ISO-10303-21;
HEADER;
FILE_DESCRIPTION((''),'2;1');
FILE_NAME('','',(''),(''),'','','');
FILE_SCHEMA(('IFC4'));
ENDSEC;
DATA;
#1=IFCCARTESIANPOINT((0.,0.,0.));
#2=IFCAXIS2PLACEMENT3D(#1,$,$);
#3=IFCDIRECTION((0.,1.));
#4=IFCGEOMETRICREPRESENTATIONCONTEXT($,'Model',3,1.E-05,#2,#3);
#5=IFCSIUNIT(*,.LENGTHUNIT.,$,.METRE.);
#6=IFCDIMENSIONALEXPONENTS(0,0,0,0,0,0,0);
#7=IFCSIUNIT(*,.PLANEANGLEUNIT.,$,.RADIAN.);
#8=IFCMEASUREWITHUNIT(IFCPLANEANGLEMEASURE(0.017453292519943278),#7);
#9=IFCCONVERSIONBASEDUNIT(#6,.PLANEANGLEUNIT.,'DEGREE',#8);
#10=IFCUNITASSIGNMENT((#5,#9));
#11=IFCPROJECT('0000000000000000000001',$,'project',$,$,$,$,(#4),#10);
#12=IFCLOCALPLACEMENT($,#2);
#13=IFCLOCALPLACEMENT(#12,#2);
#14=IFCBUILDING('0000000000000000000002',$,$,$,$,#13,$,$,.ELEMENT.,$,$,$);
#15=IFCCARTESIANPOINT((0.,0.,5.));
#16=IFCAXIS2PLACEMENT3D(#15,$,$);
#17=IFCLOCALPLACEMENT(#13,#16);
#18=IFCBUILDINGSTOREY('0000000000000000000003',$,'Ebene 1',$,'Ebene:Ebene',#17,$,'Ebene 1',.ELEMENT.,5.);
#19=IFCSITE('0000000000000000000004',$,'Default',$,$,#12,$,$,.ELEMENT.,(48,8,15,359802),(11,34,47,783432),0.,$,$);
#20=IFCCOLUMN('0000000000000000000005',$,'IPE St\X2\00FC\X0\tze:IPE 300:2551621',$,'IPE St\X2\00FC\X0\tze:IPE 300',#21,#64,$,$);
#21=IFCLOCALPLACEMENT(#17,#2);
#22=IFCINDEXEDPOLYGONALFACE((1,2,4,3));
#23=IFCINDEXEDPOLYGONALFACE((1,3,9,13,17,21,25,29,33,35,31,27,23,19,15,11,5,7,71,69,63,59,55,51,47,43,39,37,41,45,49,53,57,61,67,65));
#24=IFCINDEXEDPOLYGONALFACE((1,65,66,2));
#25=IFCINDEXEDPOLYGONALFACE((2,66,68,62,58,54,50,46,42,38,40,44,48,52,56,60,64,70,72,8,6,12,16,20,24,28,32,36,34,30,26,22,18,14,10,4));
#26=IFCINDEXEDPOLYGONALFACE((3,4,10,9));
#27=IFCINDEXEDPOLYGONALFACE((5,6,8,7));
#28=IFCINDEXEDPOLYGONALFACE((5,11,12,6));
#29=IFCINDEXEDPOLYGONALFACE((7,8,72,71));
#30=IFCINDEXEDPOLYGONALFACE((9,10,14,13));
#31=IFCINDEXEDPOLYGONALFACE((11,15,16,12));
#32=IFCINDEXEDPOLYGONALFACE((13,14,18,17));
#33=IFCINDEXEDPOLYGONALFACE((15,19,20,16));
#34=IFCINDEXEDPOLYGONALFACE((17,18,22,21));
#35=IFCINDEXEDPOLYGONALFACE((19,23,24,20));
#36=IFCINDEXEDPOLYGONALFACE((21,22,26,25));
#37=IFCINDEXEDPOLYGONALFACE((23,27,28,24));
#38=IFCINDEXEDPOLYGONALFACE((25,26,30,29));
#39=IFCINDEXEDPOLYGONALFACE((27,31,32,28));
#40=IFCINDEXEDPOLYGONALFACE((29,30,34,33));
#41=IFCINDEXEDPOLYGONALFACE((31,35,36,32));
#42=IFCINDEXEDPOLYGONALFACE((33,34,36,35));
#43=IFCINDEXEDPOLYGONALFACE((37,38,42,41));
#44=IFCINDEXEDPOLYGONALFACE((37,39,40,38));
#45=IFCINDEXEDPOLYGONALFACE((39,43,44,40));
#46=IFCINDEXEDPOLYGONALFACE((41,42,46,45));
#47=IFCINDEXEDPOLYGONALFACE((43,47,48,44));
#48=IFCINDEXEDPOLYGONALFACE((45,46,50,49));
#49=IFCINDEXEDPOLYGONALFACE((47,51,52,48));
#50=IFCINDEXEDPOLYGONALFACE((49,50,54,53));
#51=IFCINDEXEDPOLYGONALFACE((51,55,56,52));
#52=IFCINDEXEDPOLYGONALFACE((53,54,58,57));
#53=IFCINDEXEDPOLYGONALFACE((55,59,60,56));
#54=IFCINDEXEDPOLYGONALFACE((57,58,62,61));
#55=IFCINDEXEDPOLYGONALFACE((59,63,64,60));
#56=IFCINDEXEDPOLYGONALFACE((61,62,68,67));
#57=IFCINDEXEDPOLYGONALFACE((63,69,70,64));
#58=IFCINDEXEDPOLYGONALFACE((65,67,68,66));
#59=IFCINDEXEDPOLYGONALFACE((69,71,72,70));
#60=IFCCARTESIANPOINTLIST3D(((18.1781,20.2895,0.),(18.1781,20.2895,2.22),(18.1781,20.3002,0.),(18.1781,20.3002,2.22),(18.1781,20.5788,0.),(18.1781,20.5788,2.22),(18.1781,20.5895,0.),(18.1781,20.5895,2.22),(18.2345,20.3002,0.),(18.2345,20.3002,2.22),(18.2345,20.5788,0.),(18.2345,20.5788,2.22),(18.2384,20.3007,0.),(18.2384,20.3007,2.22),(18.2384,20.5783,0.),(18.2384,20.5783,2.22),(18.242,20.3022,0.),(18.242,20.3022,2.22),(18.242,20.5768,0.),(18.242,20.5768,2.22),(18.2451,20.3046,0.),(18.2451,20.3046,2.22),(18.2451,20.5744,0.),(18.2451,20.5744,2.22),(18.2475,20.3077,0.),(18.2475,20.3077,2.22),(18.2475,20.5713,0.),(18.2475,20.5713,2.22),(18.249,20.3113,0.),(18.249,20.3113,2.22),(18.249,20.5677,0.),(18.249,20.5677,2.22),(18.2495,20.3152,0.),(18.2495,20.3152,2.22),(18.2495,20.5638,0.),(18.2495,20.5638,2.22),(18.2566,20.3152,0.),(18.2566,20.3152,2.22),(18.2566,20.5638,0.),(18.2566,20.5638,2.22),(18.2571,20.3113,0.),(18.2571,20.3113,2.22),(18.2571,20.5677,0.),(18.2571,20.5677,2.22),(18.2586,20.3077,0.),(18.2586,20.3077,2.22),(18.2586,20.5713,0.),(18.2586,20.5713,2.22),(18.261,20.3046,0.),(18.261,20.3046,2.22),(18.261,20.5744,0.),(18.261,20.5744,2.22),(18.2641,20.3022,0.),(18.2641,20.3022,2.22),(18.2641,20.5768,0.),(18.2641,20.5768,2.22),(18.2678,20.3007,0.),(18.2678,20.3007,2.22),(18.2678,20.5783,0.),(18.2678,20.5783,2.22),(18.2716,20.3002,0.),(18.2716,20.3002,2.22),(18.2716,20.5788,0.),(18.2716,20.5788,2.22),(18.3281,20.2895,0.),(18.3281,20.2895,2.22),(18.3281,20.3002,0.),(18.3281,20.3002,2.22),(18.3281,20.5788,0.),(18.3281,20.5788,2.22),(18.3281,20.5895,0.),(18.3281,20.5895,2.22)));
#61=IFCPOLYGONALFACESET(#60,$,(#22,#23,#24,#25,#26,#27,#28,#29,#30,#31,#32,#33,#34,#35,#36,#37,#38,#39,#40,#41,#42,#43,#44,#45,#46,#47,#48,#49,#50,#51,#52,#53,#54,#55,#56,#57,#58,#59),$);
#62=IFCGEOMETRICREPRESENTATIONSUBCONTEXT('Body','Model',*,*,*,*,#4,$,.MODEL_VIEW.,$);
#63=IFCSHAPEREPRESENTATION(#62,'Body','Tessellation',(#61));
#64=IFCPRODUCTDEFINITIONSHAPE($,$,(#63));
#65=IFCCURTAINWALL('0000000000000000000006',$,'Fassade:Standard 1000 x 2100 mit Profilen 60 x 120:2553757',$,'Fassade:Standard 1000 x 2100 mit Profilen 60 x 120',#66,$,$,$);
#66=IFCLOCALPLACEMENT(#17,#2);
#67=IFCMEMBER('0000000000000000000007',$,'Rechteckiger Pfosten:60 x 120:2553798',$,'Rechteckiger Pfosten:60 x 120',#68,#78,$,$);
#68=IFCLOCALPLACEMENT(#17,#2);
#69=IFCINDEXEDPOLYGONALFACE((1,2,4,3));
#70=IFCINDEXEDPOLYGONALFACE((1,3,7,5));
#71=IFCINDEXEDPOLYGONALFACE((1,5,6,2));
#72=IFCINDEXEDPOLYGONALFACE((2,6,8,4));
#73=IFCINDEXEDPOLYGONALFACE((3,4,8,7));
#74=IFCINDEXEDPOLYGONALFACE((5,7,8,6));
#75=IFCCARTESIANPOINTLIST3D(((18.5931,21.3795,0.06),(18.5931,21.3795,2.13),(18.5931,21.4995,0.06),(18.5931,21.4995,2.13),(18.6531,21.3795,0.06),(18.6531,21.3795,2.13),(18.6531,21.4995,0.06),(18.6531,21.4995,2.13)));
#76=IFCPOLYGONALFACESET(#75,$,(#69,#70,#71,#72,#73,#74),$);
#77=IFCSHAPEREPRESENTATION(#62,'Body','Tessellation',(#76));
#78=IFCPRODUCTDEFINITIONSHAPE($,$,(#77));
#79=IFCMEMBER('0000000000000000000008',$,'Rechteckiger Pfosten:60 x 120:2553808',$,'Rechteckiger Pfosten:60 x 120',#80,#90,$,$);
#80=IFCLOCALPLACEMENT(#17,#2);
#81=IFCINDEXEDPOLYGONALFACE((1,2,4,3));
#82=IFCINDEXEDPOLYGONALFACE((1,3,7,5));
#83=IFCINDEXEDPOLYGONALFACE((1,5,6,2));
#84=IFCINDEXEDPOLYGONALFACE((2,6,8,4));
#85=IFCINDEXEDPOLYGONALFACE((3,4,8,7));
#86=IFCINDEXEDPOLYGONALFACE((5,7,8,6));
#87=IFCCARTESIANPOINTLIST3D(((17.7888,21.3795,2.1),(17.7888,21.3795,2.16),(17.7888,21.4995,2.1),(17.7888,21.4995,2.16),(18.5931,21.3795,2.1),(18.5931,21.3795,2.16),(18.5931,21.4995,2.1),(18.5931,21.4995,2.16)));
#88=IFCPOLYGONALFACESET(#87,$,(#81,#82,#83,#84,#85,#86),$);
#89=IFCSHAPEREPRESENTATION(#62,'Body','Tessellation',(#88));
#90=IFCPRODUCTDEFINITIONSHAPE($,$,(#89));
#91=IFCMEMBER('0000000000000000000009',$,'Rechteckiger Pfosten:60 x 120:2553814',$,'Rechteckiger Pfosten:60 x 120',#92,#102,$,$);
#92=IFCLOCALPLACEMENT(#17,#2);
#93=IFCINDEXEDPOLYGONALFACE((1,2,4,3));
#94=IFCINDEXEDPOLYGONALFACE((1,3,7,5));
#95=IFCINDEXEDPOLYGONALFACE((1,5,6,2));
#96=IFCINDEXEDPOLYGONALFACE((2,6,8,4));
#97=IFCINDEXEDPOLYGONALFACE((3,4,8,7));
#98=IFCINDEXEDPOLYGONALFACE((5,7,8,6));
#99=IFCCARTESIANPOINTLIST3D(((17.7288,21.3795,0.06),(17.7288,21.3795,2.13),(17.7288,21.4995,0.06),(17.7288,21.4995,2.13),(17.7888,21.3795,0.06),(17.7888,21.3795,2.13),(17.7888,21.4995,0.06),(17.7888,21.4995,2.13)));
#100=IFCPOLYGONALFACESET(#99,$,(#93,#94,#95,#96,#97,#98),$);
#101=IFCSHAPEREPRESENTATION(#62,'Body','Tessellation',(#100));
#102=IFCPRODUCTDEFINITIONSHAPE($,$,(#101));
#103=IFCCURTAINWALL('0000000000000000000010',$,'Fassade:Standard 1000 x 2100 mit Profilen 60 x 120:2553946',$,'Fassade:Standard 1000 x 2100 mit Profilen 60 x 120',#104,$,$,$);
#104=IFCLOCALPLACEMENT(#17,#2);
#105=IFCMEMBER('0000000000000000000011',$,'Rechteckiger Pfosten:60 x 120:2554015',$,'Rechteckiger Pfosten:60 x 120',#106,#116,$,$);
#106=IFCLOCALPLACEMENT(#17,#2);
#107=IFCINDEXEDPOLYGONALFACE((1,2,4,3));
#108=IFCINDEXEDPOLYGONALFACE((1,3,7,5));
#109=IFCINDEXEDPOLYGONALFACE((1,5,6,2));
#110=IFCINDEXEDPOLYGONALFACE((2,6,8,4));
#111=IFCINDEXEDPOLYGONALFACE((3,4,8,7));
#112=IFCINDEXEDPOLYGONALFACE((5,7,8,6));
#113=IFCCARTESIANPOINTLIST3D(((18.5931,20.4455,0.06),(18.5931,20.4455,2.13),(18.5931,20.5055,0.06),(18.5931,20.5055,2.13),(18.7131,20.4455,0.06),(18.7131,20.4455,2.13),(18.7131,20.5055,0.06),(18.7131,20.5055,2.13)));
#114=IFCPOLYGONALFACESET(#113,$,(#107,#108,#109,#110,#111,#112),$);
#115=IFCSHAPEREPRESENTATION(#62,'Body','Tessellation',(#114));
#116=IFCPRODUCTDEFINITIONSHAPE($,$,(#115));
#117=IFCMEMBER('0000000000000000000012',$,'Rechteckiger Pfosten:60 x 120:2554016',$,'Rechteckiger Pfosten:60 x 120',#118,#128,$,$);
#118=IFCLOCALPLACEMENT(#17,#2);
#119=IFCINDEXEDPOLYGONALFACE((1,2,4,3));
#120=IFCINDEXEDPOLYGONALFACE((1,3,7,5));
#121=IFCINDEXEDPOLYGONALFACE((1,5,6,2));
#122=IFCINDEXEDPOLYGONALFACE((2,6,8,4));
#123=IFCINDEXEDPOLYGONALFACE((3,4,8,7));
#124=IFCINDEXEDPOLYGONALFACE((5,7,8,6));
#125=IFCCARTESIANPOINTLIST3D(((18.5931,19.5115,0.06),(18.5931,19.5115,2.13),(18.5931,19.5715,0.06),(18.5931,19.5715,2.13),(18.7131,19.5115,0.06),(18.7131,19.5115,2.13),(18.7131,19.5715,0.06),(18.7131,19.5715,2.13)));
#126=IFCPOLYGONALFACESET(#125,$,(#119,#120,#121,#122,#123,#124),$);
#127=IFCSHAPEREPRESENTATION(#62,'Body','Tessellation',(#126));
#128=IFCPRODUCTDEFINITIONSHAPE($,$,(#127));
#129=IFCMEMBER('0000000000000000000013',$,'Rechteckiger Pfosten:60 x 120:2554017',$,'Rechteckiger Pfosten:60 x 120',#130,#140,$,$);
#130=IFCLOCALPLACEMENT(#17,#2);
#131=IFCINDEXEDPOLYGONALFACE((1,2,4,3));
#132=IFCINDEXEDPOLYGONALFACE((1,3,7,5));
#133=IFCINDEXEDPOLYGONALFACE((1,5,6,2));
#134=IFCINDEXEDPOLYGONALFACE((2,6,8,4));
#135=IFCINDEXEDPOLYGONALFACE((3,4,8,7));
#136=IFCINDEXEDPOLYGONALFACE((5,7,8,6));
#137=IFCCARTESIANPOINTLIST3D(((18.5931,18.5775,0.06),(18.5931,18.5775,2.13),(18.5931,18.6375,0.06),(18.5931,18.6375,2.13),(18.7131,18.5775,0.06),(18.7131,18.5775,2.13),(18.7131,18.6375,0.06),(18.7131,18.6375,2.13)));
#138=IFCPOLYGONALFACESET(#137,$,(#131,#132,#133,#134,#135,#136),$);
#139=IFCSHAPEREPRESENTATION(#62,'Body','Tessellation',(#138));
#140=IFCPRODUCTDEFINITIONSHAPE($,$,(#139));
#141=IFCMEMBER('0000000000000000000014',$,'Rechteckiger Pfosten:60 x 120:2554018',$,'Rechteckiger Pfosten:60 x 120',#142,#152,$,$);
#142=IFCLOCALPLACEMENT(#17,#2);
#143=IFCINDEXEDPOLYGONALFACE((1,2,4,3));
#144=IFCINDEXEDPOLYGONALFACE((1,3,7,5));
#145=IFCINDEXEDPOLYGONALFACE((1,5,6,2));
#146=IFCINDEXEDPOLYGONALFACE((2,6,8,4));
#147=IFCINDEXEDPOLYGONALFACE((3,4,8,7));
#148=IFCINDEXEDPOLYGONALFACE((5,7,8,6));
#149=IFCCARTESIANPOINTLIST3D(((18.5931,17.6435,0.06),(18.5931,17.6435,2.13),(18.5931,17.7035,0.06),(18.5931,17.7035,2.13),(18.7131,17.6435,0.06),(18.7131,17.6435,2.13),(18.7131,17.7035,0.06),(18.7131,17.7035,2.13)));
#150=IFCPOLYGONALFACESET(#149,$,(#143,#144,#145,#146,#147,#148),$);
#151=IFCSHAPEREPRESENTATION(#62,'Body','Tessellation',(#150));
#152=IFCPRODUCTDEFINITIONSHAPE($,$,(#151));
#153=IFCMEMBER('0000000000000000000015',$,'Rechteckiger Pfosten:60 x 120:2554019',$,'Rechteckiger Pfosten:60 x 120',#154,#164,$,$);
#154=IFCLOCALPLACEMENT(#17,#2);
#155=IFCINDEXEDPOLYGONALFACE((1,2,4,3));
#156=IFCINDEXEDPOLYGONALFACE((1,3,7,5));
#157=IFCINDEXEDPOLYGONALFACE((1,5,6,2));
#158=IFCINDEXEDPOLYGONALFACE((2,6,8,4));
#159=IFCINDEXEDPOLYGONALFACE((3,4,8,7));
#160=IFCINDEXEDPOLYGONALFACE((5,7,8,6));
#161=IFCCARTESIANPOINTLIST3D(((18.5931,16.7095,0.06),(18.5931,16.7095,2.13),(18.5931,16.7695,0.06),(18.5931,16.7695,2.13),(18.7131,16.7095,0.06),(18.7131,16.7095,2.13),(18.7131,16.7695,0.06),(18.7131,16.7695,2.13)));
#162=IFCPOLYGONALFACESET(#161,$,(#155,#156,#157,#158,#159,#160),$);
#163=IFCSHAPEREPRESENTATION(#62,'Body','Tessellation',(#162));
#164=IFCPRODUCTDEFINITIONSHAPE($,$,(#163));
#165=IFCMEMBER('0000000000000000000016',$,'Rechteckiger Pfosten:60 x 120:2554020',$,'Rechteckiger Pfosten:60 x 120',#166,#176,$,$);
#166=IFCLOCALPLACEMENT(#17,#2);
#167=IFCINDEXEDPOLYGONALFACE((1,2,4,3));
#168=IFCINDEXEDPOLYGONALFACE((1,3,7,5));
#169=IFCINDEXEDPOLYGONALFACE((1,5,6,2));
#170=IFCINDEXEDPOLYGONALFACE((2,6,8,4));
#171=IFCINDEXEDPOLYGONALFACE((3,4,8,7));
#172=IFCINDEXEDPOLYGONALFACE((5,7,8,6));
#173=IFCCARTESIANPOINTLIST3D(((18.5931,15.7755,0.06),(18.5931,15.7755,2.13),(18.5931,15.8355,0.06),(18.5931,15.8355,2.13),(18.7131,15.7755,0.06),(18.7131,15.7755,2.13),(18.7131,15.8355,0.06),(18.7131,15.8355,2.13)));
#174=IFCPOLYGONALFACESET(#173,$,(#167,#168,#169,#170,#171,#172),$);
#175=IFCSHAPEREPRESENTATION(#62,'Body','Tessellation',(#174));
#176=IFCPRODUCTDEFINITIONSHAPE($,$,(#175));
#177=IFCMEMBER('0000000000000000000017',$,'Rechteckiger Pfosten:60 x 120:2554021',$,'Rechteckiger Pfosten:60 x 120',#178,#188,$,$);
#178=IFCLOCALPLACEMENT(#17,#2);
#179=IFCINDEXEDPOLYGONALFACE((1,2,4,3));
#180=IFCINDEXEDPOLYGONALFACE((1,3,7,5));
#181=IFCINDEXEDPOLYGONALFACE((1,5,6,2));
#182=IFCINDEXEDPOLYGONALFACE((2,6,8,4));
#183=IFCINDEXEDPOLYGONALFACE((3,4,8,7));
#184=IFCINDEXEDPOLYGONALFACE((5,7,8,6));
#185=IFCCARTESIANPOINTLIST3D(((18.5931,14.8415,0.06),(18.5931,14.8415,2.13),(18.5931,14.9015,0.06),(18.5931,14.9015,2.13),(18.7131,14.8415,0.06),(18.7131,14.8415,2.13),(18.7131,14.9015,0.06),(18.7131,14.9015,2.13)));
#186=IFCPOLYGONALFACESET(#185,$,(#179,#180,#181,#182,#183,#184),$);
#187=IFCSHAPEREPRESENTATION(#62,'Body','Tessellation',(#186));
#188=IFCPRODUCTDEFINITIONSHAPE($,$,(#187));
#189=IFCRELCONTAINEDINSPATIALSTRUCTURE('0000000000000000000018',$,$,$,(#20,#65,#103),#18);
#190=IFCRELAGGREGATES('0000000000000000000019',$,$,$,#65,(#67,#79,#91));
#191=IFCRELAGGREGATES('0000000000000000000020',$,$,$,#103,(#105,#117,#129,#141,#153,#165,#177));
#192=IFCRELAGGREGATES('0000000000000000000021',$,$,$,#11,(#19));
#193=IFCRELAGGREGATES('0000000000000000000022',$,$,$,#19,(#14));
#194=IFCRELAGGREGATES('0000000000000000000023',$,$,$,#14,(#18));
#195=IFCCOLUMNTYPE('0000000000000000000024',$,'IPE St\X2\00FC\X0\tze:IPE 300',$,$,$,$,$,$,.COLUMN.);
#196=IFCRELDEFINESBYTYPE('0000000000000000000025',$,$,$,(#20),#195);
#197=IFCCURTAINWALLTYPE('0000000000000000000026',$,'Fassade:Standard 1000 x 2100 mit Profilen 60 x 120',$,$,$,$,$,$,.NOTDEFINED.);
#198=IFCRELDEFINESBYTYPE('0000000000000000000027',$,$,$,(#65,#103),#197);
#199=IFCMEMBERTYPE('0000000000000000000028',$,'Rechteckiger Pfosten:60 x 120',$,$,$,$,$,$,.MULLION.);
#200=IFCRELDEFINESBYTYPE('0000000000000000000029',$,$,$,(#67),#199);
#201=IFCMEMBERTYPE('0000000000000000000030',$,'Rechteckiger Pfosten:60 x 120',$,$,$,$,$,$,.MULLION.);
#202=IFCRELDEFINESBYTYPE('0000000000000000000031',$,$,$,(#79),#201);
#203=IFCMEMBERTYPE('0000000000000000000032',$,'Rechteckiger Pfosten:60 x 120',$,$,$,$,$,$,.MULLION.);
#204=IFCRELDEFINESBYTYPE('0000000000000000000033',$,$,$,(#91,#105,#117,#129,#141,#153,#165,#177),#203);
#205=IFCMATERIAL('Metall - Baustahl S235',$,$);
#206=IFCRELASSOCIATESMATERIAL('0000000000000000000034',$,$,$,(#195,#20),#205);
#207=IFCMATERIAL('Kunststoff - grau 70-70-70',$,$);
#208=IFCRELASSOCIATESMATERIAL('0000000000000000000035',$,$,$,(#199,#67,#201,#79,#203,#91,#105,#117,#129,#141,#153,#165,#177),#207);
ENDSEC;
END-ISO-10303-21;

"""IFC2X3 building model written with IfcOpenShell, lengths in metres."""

from ifc_helpers import new_model, entity, si_unit, converted_unit, direction, frame, frame_2d, origin, origin_2d_with_axis, place, context, subcontext, project, spatial, rectangle, i_section, extrude, source, transform, mapped, material, type_object, type_shapes, element, aggregate, save


model = new_model("IFC2X3")

# Units and contexts
model_context = context("Model", 3, precision=1e-05, world=origin(), true_north=direction((0.0, 1.0)))
body_context = subcontext(model_context, "Body", "Model", "MODEL_VIEW")
ifc_project = project(units=[si_unit("LENGTHUNIT", "METRE"), converted_unit("PLANEANGLEUNIT", "DEGREE", entity("IfcPlaneAngleMeasure", 0.017453292519943278), si_unit("PLANEANGLEUNIT", "RADIAN"), dimensions=[0, 0, 0, 0, 0, 0, 0])], contexts=[model_context])

# Site, building, storey
site_placement = place(None, origin())
site = spatial("IfcSite", under=ifc_project, at=site_placement, Name="Default", CompositionType="ELEMENT", RefLatitude=(48, 8, 15, 359802), RefLongitude=(11, 34, 47, 783432), RefElevation=0.0)
building_placement = place(site_placement, origin())
building = spatial("IfcBuilding", under=site, at=building_placement, CompositionType="ELEMENT")
storey_placement = place(building_placement, frame((0.0, 0.0, 5.0)))
storey = spatial("IfcBuildingStorey", under=building, at=storey_placement, Name="Ebene 1", ObjectType="Ebene:Ebene", LongName="Ebene 1", CompositionType="ELEMENT", Elevation=5.0)

# Column
ifc_material_1 = material(Name="Metall - Baustahl S235")
column_type = type_object("IfcColumnType", Name="IPE Stütze:IPE 300", PredefinedType="COLUMN", material=ifc_material_1)
shared_shape_1 = source(origin(), body_context, "Body", "SweptSolid", [
    extrude(i_section(OverallWidth=0.15, OverallDepth=0.3, WebThickness=0.0071, FlangeThickness=0.0107, FilletRadius=0.015, at=origin_2d_with_axis()), frame((0.0, 0.0, 5.0), z_axis=(0.0, 0.0, 1.0), x_axis=(-1.0, 0.0, 0.0)), (0.0, 0.0, 1.0), 2.22),
])
type_shapes(column_type, [shared_shape_1])
column_placement = place(storey_placement, frame((18.2531, 20.4395, -5.0)))
element("IfcColumn", 1, at=column_placement, inside=storey, type_object=column_type, material=ifc_material_1, Name="IPE Stütze:IPE 300:2551621", ObjectType="IPE Stütze:IPE 300", context=body_context, shape_type="MappedRepresentation", body=[
    mapped(shared_shape_1, transform((0.0, 0.0, 0.0), scale=1.0)),
])

# Curtain walls, members
curtain_wall_type = type_object("IfcCurtainWallType", Name="Fassade:Standard 1000 x 2100 mit Profilen 60 x 120", PredefinedType="NOTDEFINED")
curtain_wall_1_placement = place(storey_placement, frame((0.0, 0.0, -5.0)))
curtain_wall_1 = element("IfcCurtainWall", 2, at=curtain_wall_1_placement, inside=storey, type_object=curtain_wall_type, Name="Fassade:Standard 1000 x 2100 mit Profilen 60 x 120:2553757", ObjectType="Fassade:Standard 1000 x 2100 mit Profilen 60 x 120")
ifc_material_2 = material(Name="Kunststoff - grau 70-70-70")
member_type_1 = type_object("IfcMemberType", Name="Rechteckiger Pfosten:60 x 120", PredefinedType="MULLION", material=ifc_material_2)
shared_shape_2 = source(origin(), body_context, "Body", "SweptSolid", [
    extrude(rectangle(XDim=0.06, YDim=0.12, at=origin_2d_with_axis()), frame((-0.03, 0.0, -2.07), z_axis=(0.0, 0.0, 1.0), x_axis=(-1.0, 0.0, 0.0)), (0.0, 0.0, 1.0), 2.07),
])
type_shapes(member_type_1, [shared_shape_2])
member_1_placement = place(curtain_wall_1_placement, frame((18.6531, 21.4395, 5.06), z_axis=(0.0, 0.0, -1.0), x_axis=(1.0, 0.0, 0.0)))
member_1 = element("IfcMember", 3, at=member_1_placement, type_object=member_type_1, material=ifc_material_2, Name="Rechteckiger Pfosten:60 x 120:2553798", ObjectType="Rechteckiger Pfosten:60 x 120", context=body_context, shape_type="MappedRepresentation", body=[
    mapped(shared_shape_2, transform((0.0, 0.0, 0.0), scale=1.0)),
])
member_type_2 = type_object("IfcMemberType", Name="Rechteckiger Pfosten:60 x 120", PredefinedType="MULLION", material=ifc_material_2)
shared_shape_3 = source(origin(), body_context, "Body", "SweptSolid", [
    extrude(rectangle(XDim=0.06, YDim=0.12, at=frame_2d((0.0, 0.0), x_axis=(1.0, 0.0))), frame((0.0, 0.0, -0.8043), z_axis=(0.0, 0.0, 1.0), x_axis=(-1.0, 0.0, 0.0)), (0.0, 0.0, 1.0), 0.8043),
])
type_shapes(member_type_2, [shared_shape_3])
member_2_placement = place(curtain_wall_1_placement, frame((18.5931, 21.4395, 7.13), z_axis=(1.0, 0.0, 0.0), x_axis=(0.0, 0.0, 1.0)))
member_2 = element("IfcMember", 4, at=member_2_placement, type_object=member_type_2, material=ifc_material_2, Name="Rechteckiger Pfosten:60 x 120:2553808", ObjectType="Rechteckiger Pfosten:60 x 120", context=body_context, shape_type="MappedRepresentation", body=[
    mapped(shared_shape_3, transform((0.0, 0.0, 0.0), scale=1.0)),
])
member_type_3 = type_object("IfcMemberType", Name="Rechteckiger Pfosten:60 x 120", PredefinedType="MULLION", material=ifc_material_2)
shared_shape_4 = source(origin(), body_context, "Body", "SweptSolid", [
    extrude(rectangle(XDim=0.06, YDim=0.12, at=origin_2d_with_axis()), frame((0.0, 0.0, -2.07), z_axis=(0.0, 0.0, 1.0), x_axis=(-1.0, 0.0, 0.0)), (0.0, 0.0, 1.0), 2.07),
])
type_shapes(member_type_3, [shared_shape_4])
member_3_placement = place(curtain_wall_1_placement, frame((17.7588, 21.4395, 5.06), z_axis=(0.0, 0.0, -1.0), x_axis=(1.0, 0.0, 0.0)))
member_3 = element("IfcMember", 5, at=member_3_placement, type_object=member_type_3, material=ifc_material_2, Name="Rechteckiger Pfosten:60 x 120:2553814", ObjectType="Rechteckiger Pfosten:60 x 120", context=body_context, shape_type="MappedRepresentation", body=[
    mapped(shared_shape_4, transform((0.0, 0.0, 0.0), scale=1.0)),
])
curtain_wall_2_placement = place(storey_placement, frame((0.0, 0.0, -5.0)))
curtain_wall_2 = element("IfcCurtainWall", 6, at=curtain_wall_2_placement, inside=storey, type_object=curtain_wall_type, Name="Fassade:Standard 1000 x 2100 mit Profilen 60 x 120:2553946", ObjectType="Fassade:Standard 1000 x 2100 mit Profilen 60 x 120")
member_4_placement = place(curtain_wall_2_placement, frame((18.6531, 20.4755, 5.06), z_axis=(0.0, 0.0, -1.0), x_axis=(0.0, -1.0, 0.0)))
member_4 = element("IfcMember", 7, at=member_4_placement, type_object=member_type_3, material=ifc_material_2, Name="Rechteckiger Pfosten:60 x 120:2554015", ObjectType="Rechteckiger Pfosten:60 x 120", context=body_context, shape_type="MappedRepresentation", body=[
    mapped(shared_shape_4, transform((0.0, 0.0, 0.0), scale=1.0)),
])
member_5_placement = place(curtain_wall_2_placement, frame((18.6531, 19.5415, 5.06), z_axis=(0.0, 0.0, -1.0), x_axis=(0.0, -1.0, 0.0)))
member_5 = element("IfcMember", 8, at=member_5_placement, type_object=member_type_3, material=ifc_material_2, Name="Rechteckiger Pfosten:60 x 120:2554016", ObjectType="Rechteckiger Pfosten:60 x 120", context=body_context, shape_type="MappedRepresentation", body=[
    mapped(shared_shape_4, transform((0.0, 0.0, 0.0), scale=1.0)),
])
member_6_placement = place(curtain_wall_2_placement, frame((18.6531, 18.6075, 5.06), z_axis=(0.0, 0.0, -1.0), x_axis=(0.0, -1.0, 0.0)))
member_6 = element("IfcMember", 9, at=member_6_placement, type_object=member_type_3, material=ifc_material_2, Name="Rechteckiger Pfosten:60 x 120:2554017", ObjectType="Rechteckiger Pfosten:60 x 120", context=body_context, shape_type="MappedRepresentation", body=[
    mapped(shared_shape_4, transform((0.0, 0.0, 0.0), scale=1.0)),
])
member_7_placement = place(curtain_wall_2_placement, frame((18.6531, 17.6735, 5.06), z_axis=(0.0, 0.0, -1.0), x_axis=(0.0, -1.0, 0.0)))
member_7 = element("IfcMember", 10, at=member_7_placement, type_object=member_type_3, material=ifc_material_2, Name="Rechteckiger Pfosten:60 x 120:2554018", ObjectType="Rechteckiger Pfosten:60 x 120", context=body_context, shape_type="MappedRepresentation", body=[
    mapped(shared_shape_4, transform((0.0, 0.0, 0.0), scale=1.0)),
])
member_8_placement = place(curtain_wall_2_placement, frame((18.6531, 16.7395, 5.06), z_axis=(0.0, 0.0, -1.0), x_axis=(0.0, -1.0, 0.0)))
member_8 = element("IfcMember", 11, at=member_8_placement, type_object=member_type_3, material=ifc_material_2, Name="Rechteckiger Pfosten:60 x 120:2554019", ObjectType="Rechteckiger Pfosten:60 x 120", context=body_context, shape_type="MappedRepresentation", body=[
    mapped(shared_shape_4, transform((0.0, 0.0, 0.0), scale=1.0)),
])
member_9_placement = place(curtain_wall_2_placement, frame((18.6531, 15.8055, 5.06), z_axis=(0.0, 0.0, -1.0), x_axis=(0.0, -1.0, 0.0)))
member_9 = element("IfcMember", 12, at=member_9_placement, type_object=member_type_3, material=ifc_material_2, Name="Rechteckiger Pfosten:60 x 120:2554020", ObjectType="Rechteckiger Pfosten:60 x 120", context=body_context, shape_type="MappedRepresentation", body=[
    mapped(shared_shape_4, transform((0.0, 0.0, 0.0), scale=1.0)),
])
member_10_placement = place(curtain_wall_2_placement, frame((18.6531, 14.8715, 5.06), z_axis=(0.0, 0.0, -1.0), x_axis=(0.0, -1.0, 0.0)))
member_10 = element("IfcMember", 13, at=member_10_placement, type_object=member_type_3, material=ifc_material_2, Name="Rechteckiger Pfosten:60 x 120:2554021", ObjectType="Rechteckiger Pfosten:60 x 120", context=body_context, shape_type="MappedRepresentation", body=[
    mapped(shared_shape_4, transform((0.0, 0.0, 0.0), scale=1.0)),
])

aggregate(curtain_wall_1, [member_1, member_2, member_3])
aggregate(curtain_wall_2, [member_4, member_5, member_6, member_7, member_8, member_9, member_10])

save(model, "model.ifc")
